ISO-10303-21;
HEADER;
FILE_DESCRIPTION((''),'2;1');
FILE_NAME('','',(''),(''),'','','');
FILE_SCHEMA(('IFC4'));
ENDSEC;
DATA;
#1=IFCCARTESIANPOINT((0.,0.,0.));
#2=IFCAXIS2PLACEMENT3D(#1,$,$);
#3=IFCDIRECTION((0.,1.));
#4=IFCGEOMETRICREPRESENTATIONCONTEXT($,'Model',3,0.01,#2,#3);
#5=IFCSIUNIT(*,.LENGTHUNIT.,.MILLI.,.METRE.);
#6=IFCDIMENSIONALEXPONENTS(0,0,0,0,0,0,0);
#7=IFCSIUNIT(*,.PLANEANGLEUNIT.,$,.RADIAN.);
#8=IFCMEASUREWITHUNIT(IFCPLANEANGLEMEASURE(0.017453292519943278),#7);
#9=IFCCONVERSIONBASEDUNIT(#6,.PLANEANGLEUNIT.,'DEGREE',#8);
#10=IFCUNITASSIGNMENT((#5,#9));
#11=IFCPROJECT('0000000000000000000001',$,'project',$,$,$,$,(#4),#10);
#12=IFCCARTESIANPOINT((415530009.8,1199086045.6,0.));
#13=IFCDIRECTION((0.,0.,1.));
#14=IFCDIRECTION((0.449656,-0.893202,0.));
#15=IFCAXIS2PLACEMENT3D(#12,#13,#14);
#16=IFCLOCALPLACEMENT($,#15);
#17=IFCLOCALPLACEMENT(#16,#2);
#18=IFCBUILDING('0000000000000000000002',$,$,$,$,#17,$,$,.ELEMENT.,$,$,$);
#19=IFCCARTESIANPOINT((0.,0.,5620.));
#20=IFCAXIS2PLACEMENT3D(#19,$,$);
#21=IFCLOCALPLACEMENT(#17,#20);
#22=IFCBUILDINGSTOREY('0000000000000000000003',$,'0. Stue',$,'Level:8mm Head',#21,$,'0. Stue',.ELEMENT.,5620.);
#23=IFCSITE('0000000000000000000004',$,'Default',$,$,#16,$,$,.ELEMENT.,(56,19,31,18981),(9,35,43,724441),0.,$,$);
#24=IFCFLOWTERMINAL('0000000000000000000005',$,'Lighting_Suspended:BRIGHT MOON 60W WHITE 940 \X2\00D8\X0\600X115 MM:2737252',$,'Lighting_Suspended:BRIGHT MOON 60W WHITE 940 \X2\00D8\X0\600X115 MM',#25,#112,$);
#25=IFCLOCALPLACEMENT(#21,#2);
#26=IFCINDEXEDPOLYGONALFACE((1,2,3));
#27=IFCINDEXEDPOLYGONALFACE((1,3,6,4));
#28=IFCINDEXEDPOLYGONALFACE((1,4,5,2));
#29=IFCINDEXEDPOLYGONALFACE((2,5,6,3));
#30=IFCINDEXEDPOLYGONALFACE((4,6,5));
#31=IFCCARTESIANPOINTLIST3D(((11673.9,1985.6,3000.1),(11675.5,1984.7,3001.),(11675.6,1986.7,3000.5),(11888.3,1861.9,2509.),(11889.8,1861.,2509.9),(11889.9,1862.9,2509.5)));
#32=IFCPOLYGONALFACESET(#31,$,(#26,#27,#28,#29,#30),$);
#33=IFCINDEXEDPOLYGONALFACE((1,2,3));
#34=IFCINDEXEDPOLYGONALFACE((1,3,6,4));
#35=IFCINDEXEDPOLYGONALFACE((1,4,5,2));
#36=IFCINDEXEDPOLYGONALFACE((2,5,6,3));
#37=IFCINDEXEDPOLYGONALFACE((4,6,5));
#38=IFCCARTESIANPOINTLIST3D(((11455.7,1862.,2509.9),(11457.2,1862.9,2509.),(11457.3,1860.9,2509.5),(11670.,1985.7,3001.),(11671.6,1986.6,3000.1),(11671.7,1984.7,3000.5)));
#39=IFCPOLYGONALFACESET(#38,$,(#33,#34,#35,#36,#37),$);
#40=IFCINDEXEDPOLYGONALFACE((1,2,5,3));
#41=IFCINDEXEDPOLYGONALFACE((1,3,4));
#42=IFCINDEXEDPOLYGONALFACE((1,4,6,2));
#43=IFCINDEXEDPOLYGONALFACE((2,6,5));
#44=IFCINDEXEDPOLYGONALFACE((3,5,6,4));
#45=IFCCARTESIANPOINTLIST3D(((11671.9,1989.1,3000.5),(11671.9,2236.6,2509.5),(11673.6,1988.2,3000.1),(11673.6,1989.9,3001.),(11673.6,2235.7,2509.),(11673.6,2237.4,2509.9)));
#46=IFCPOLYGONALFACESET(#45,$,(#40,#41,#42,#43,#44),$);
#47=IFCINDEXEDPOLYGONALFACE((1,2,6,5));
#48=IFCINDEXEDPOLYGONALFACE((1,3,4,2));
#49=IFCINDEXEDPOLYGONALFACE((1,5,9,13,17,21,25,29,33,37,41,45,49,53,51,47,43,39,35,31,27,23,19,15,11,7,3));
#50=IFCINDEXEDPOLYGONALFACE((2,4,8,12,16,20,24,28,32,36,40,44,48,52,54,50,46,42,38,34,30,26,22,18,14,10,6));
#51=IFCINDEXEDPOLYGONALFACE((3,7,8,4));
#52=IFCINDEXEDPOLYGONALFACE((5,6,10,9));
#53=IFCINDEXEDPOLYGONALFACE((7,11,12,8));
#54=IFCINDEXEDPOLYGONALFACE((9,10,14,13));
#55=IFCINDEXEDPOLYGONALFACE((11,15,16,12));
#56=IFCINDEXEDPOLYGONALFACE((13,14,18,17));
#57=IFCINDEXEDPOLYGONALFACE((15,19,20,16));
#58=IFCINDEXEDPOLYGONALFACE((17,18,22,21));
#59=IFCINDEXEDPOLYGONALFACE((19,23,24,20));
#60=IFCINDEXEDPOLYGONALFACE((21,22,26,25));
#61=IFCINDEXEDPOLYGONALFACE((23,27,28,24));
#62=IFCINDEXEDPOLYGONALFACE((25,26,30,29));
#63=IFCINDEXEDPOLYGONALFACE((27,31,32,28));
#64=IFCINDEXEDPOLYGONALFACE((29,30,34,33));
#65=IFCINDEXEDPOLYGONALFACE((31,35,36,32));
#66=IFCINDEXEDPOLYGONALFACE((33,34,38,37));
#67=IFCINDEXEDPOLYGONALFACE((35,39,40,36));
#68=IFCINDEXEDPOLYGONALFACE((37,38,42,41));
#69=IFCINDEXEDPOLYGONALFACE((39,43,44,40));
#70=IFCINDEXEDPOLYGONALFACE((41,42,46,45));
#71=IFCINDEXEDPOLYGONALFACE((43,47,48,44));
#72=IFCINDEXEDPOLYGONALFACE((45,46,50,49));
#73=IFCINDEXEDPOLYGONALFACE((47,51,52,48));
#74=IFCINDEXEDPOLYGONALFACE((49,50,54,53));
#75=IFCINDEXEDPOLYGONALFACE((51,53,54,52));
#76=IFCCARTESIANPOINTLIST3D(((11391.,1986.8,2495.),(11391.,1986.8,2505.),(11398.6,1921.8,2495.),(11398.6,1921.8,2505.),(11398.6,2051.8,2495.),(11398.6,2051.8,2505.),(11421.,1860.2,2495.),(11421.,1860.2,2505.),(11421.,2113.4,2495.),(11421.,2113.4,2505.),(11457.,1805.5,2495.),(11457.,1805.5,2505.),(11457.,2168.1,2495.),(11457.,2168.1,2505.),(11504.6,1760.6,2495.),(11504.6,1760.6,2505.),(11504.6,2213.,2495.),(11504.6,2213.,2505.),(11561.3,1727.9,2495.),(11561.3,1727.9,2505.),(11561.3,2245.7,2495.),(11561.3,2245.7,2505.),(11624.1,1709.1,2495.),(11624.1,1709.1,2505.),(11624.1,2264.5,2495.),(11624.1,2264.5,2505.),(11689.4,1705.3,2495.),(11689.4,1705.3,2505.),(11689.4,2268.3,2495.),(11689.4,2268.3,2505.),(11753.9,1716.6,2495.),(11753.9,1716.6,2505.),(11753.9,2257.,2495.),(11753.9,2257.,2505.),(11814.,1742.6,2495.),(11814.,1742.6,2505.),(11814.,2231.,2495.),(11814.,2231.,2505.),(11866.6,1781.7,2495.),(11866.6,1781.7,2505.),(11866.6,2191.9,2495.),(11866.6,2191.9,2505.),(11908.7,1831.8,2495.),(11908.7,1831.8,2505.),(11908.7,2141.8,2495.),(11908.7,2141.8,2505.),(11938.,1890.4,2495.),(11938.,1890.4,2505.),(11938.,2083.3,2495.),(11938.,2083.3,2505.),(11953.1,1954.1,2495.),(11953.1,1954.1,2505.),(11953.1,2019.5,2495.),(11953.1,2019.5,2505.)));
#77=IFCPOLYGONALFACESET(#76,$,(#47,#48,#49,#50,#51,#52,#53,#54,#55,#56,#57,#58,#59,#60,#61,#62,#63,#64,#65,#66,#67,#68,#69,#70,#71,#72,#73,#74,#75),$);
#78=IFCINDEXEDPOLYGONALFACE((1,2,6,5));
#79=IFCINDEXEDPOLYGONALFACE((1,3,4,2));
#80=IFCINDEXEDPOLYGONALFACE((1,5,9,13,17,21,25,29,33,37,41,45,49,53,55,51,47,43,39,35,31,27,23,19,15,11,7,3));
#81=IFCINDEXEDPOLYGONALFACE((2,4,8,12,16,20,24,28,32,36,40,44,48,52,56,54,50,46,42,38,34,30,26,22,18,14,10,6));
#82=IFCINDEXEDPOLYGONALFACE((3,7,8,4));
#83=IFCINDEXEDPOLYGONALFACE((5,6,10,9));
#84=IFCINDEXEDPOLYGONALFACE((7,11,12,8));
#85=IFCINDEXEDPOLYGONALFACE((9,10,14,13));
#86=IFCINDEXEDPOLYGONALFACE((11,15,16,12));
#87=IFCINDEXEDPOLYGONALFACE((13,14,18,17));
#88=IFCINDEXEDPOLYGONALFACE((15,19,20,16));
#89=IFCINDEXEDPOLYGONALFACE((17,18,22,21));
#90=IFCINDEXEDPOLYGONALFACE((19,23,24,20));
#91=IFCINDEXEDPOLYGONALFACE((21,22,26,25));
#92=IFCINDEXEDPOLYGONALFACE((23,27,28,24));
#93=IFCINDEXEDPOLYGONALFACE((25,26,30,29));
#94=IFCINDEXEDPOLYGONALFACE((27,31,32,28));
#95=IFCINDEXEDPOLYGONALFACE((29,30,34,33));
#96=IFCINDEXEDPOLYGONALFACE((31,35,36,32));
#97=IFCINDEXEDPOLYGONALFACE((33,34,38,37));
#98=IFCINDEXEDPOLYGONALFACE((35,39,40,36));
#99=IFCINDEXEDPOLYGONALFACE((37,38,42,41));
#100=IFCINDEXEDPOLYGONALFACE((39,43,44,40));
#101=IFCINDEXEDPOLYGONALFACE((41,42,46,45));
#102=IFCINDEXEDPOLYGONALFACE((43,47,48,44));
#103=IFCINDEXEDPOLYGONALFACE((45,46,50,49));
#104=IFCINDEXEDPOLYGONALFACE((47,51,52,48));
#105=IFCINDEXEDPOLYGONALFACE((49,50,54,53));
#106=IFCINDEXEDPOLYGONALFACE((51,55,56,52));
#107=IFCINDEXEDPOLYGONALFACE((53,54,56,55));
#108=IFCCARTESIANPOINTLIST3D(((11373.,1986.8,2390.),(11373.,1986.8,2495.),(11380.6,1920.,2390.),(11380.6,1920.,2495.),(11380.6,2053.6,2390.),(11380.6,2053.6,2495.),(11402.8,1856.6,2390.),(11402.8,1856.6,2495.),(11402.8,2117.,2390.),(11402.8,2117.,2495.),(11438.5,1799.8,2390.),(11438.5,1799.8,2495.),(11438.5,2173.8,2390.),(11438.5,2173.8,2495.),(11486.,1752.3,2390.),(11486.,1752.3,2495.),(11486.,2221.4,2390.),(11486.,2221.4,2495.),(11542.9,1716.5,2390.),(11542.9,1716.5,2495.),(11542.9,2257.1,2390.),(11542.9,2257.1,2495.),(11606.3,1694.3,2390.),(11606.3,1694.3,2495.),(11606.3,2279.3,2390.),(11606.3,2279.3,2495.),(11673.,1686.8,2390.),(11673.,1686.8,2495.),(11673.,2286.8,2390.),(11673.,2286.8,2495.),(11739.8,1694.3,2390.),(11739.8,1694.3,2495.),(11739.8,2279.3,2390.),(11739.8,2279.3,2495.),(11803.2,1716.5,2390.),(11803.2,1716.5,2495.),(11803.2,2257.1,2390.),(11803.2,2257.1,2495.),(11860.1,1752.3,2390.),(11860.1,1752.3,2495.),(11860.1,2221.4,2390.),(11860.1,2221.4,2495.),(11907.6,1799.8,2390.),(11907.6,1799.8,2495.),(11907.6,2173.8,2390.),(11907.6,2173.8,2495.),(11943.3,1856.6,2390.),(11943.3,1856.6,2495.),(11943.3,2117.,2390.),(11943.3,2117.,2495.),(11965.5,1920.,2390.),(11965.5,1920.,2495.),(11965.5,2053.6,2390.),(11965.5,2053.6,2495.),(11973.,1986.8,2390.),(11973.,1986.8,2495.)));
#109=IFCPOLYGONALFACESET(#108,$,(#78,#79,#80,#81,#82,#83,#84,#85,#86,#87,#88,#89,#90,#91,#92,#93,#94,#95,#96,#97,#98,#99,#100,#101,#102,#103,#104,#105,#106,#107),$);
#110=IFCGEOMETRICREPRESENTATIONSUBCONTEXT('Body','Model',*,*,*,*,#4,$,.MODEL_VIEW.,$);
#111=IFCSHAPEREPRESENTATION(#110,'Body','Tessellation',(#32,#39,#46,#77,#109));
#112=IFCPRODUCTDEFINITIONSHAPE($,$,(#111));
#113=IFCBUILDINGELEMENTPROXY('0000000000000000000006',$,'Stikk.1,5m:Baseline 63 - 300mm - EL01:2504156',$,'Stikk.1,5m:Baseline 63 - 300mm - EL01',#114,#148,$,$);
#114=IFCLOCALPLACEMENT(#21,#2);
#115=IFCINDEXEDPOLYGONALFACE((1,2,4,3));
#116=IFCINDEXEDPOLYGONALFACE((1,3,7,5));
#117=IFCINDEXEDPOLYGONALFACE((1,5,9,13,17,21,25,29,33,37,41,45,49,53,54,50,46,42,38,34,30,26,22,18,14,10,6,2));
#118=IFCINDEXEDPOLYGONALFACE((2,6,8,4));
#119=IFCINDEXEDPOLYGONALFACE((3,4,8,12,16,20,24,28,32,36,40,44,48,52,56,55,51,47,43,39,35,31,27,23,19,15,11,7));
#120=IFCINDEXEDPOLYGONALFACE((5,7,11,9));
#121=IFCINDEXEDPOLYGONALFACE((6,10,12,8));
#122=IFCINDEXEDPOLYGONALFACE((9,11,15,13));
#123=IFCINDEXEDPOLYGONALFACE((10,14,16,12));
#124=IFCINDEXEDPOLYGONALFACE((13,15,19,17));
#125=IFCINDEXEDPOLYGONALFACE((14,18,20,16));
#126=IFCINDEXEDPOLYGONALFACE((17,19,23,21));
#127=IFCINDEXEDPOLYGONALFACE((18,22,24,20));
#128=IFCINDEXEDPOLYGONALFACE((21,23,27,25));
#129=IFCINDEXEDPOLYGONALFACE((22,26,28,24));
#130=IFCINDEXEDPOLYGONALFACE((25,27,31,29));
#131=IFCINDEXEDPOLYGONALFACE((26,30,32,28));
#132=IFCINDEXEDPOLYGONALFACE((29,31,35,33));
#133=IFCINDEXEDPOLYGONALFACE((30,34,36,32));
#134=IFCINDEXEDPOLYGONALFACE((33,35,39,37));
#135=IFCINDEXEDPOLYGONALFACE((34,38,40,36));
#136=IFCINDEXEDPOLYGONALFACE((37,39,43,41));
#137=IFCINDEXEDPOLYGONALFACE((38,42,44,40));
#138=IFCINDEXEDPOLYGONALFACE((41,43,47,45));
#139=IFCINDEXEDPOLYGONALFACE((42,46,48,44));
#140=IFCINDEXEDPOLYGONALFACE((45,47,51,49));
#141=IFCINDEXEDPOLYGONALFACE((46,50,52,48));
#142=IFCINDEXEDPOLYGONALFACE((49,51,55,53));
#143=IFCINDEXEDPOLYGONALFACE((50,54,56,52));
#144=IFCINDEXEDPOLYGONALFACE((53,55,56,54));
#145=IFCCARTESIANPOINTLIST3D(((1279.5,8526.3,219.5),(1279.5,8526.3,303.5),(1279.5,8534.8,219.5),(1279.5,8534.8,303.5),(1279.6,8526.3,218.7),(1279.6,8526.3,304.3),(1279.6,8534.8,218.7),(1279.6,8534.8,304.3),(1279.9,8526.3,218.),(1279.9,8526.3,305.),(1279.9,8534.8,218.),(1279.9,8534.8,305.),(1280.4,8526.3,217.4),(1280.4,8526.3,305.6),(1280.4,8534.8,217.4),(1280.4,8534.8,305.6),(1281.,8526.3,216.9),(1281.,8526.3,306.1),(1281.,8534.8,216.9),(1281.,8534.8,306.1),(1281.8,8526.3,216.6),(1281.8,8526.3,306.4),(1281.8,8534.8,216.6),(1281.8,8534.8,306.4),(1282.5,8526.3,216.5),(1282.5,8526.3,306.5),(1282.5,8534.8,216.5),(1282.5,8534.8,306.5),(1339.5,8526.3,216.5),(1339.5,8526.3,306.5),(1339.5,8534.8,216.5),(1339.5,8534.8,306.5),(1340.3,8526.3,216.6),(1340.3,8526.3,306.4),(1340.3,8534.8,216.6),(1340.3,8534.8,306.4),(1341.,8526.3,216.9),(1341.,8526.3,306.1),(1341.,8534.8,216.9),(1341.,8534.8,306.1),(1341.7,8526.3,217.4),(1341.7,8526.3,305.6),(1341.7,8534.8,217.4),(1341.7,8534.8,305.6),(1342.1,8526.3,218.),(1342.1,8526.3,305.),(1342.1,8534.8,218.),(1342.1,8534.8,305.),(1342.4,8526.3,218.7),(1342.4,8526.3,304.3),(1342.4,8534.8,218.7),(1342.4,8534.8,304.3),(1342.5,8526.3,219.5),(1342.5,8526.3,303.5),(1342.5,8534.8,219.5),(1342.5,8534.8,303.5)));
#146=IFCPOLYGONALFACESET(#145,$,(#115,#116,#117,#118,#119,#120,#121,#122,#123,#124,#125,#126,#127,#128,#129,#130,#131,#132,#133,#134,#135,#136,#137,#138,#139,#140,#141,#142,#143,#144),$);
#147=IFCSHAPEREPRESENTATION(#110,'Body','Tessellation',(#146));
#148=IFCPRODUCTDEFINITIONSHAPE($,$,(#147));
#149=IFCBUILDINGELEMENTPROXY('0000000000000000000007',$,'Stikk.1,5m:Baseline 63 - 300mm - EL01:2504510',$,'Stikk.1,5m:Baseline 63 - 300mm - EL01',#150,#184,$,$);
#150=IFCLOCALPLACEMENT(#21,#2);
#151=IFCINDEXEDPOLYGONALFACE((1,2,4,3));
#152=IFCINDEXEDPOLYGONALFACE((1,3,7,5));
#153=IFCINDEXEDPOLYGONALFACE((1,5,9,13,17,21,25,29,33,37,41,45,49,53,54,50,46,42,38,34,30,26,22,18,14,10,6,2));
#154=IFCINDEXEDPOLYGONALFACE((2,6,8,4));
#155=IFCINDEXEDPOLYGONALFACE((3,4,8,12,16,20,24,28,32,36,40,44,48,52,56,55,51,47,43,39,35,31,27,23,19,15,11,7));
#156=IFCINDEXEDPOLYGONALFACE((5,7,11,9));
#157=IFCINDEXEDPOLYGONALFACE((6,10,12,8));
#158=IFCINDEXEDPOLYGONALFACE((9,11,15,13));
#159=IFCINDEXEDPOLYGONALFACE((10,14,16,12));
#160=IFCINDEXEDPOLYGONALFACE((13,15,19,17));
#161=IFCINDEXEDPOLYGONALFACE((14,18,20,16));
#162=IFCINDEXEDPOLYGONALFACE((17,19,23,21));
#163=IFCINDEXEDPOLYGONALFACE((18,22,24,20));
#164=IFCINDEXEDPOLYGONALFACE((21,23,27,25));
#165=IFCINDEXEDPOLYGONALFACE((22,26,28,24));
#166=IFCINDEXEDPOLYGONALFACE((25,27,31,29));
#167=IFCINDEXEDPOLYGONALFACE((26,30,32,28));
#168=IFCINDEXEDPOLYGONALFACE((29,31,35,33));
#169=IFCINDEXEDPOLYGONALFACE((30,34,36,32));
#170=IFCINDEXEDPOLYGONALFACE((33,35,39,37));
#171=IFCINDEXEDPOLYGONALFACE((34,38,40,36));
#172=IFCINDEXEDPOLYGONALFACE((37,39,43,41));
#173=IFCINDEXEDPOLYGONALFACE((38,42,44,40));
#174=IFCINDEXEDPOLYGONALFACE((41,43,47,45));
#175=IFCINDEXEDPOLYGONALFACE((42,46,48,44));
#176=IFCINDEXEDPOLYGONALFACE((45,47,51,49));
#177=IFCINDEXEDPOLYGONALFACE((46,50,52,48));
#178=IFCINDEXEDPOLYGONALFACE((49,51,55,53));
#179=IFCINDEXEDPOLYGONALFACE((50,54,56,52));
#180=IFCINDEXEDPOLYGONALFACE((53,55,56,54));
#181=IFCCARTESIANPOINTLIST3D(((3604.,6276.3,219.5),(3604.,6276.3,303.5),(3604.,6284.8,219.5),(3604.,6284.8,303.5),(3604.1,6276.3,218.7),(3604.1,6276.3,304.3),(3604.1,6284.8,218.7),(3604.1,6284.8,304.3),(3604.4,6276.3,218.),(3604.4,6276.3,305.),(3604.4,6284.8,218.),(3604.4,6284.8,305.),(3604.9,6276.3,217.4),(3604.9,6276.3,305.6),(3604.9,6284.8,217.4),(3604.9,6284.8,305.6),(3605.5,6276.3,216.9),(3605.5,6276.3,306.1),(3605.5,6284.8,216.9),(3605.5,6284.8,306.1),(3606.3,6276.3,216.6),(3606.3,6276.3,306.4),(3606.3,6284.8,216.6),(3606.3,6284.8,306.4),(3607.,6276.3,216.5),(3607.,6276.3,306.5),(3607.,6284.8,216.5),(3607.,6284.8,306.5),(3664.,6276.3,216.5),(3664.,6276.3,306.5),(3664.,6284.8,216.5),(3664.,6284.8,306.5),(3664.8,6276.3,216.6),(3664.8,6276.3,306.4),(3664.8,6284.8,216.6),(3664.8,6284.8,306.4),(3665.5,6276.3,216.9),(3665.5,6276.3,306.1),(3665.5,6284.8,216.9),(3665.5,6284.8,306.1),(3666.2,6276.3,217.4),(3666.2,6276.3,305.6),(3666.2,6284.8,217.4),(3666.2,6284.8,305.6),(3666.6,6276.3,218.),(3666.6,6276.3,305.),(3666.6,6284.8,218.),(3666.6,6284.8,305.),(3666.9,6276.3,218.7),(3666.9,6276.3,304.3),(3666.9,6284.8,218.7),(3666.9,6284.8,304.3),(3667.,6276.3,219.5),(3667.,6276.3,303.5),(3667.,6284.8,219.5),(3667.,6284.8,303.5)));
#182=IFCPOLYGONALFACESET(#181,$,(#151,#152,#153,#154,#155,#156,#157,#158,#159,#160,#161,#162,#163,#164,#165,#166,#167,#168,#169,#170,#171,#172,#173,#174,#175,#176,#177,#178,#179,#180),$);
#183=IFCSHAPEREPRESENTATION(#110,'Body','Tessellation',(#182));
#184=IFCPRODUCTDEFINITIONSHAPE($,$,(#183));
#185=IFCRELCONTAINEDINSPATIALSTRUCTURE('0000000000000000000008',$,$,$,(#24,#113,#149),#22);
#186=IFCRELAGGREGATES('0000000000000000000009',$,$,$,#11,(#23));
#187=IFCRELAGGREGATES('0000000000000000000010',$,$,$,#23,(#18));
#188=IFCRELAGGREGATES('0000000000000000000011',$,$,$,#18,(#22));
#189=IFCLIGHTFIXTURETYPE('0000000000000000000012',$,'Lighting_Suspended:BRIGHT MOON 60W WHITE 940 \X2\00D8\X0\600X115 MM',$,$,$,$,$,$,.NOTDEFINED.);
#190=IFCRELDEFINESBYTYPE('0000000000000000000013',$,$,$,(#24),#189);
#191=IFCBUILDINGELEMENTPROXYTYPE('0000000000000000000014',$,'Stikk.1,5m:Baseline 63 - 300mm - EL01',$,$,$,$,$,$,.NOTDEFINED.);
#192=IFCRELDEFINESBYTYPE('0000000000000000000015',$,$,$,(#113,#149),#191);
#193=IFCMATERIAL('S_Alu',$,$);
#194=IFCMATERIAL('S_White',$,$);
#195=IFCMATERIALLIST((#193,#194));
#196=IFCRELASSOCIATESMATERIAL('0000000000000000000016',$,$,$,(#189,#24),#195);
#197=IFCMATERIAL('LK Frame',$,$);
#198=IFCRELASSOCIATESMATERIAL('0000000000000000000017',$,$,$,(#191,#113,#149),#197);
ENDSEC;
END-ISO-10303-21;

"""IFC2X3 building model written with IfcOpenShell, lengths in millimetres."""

from ifc_helpers import new_model, entity, si_unit, converted_unit, direction, frame, frame_2d, origin, place, context, subcontext, project, spatial, polyline, circle_curve, parameter, trimmed, segment, composite_curve, circle, outline, extrude, source, transform, mapped, material, material_list, type_object, type_shapes, element, save


model = new_model("IFC2X3")

# Units and contexts
model_context = context("Model", 3, precision=0.01, world=origin(), true_north=direction((0.0, 1.0)))
body_context = subcontext(model_context, "Body", "Model", "MODEL_VIEW")
ifc_project = project(units=[si_unit("LENGTHUNIT", "METRE", prefix="MILLI"), converted_unit("PLANEANGLEUNIT", "DEGREE", entity("IfcPlaneAngleMeasure", 0.017453292519943278), si_unit("PLANEANGLEUNIT", "RADIAN"), dimensions=[0, 0, 0, 0, 0, 0, 0])], contexts=[model_context])

# Site, building, storey
site_placement = place(None, frame((415530009.8, 1199086045.6, 0.0), z_axis=(0.0, 0.0, 1.0), x_axis=(0.449656, -0.893202, 0.0)))
site = spatial("IfcSite", under=ifc_project, at=site_placement, Name="Default", CompositionType="ELEMENT", RefLatitude=(56, 19, 31, 18981), RefLongitude=(9, 35, 43, 724441), RefElevation=0.0)
building_placement = place(site_placement, origin())
building = spatial("IfcBuilding", under=site, at=building_placement, CompositionType="ELEMENT")
storey_placement = place(building_placement, frame((0.0, 0.0, 5620.0)))
storey = spatial("IfcBuildingStorey", under=building, at=storey_placement, Name="0. Stue", ObjectType="Level:8mm Head", LongName="0. Stue", CompositionType="ELEMENT", Elevation=5620.0)

# Flow terminal
ifc_material_1 = material(Name="S_Alu")
ifc_material_2 = material(Name="S_White")
ifc_material_list = material_list([ifc_material_1, ifc_material_2])
light_fixture_type_1 = type_object("IfcLightFixtureType", Name="Lighting_Suspended:BRIGHT MOON 60W WHITE 940 Ø600X115 MM", PredefinedType="NOTDEFINED", material=ifc_material_list)
shared_shape_1 = source(origin(), body_context, "Body", "SweptSolid", [
    extrude(outline(polyline([(-1.0, -0.6), (1.0, -0.6), (0.0, 1.2), (-1.0, -0.6)])), frame((-216.3, 124.9, -495.5), z_axis=(0.389771, -0.225034, 0.892994), x_axis=(-0.773355, 0.446497, 0.450069)), (0.0, 0.0, 1.0), 549.9),
    extrude(outline(polyline([(-1.0, -0.6), (1.0, -0.6), (0.0, 1.2), (-1.0, -0.6)])), frame((216.3, 124.9, -495.5), z_axis=(-0.389771, -0.225034, 0.892994), x_axis=(0.773355, 0.446497, 0.450069)), (0.0, 0.0, 1.0), 549.9),
    extrude(outline(polyline([(-1.0, -0.6), (1.0, -0.6), (0.0, 1.2), (-1.0, -0.6)])), frame((0.0, -249.7, -495.5), z_axis=(0.0, 0.450069, 0.892994), x_axis=(0.0, -0.892994, 0.450069)), (0.0, 0.0, 1.0), 549.9),
    extrude(circle(Radius=282.0, at=frame_2d((0.0, 0.0), x_axis=(1.0, 0.0))), frame((0.0, 0.0, -510.0)), (0.0, 0.0, 1.0), 10.0),
    extrude(circle(Radius=300.0, at=frame_2d((0.0, 0.0), x_axis=(1.0, 0.0))), frame((0.0, 0.0, -615.0)), (0.0, 0.0, 1.0), 105.0),
])
type_shapes(light_fixture_type_1, [shared_shape_1])
flow_terminal_placement = place(storey_placement, frame((11673.0, 1986.8, 3005.0), z_axis=(0.0, 0.0, 1.0), x_axis=(-1.0, 0.0, 0.0)))
element("IfcFlowTerminal", 1, at=flow_terminal_placement, inside=storey, type_object=light_fixture_type_1, material=ifc_material_list, Name="Lighting_Suspended:BRIGHT MOON 60W WHITE 940 Ø600X115 MM:2737252", ObjectType="Lighting_Suspended:BRIGHT MOON 60W WHITE 940 Ø600X115 MM", context=body_context, shape_type="MappedRepresentation", body=[
    mapped(shared_shape_1, transform((0.0, 0.0, 0.0), scale=1.0)),
])

# Building element proxies
ifc_material_3 = material(Name="LK Frame")
building_element_proxy_type_1 = type_object("IfcBuildingElementProxyType", Name="Stikk.1,5m:Baseline 63 - 300mm - EL01", PredefinedType="NOTDEFINED", material=ifc_material_3)
shared_shape_2 = source(origin(), body_context, "Body", "SweptSolid", [
    extrude(outline(composite_curve([segment(polyline([(-42.0, -31.5), (42.0, -31.5)]), True, "CONTINUOUS"), segment(trimmed(circle_curve(frame_2d((42.0, -28.5), x_axis=(-1.0, 0.0)), 3.0), [parameter(90.0)], [parameter(180.0)], True, "PARAMETER"), True, "CONTINUOUS"), segment(polyline([(45.0, -28.5), (45.0, 28.5)]), True, "CONTINUOUS"), segment(trimmed(circle_curve(frame_2d((42.0, 28.5), x_axis=(-1.0, 0.0)), 3.0), [parameter(180.0)], [parameter(270.0)], True, "PARAMETER"), True, "CONTINUOUS"), segment(polyline([(42.0, 31.5), (-42.0, 31.5)]), True, "CONTINUOUS"), segment(trimmed(circle_curve(frame_2d((-42.0, 28.5), x_axis=(1.0, 0.0)), 3.0), [parameter(90.0)], [parameter(180.0)], True, "PARAMETER"), True, "CONTINUOUS"), segment(polyline([(-45.0, 28.5), (-45.0, -28.5)]), True, "CONTINUOUS"), segment(trimmed(circle_curve(frame_2d((-42.0, -28.5), x_axis=(1.0, 0.0)), 3.0), [parameter(180.0)], [parameter(270.0)], True, "PARAMETER"), True, "CONTINUOUS")], self_intersect=False)), frame((0.0, -38.5, 0.0), z_axis=(0.0, 0.0, 1.0), x_axis=(0.0, 1.0, 0.0)), (0.0, 0.0, 1.0), 8.5),
])
type_shapes(building_element_proxy_type_1, [shared_shape_2])
for number, where, z_axis, x_axis, name in (
    (2, (1311.0, 8526.3, 300.0), (0.0, 1.0, 0.0), (-1.0, 0.0, 0.0), "Stikk.1,5m:Baseline 63 - 300mm - EL01:2504156"),
    (3, (3635.5, 6276.3, 300.0), (0.0, 1.0, 0.0), (-1.0, 0.0, 0.0), "Stikk.1,5m:Baseline 63 - 300mm - EL01:2504510"),
):
    element("IfcBuildingElementProxy", number, at=place(storey_placement, frame(where, z_axis=z_axis, x_axis=x_axis)), inside=storey, type_object=building_element_proxy_type_1, material=ifc_material_3, Name=name, ObjectType="Stikk.1,5m:Baseline 63 - 300mm - EL01", context=body_context, shape_type="MappedRepresentation", body=[
        mapped(shared_shape_2, transform((0.0, 0.0, 0.0), scale=1.0)),
    ])

save(model, "model.ifc")
